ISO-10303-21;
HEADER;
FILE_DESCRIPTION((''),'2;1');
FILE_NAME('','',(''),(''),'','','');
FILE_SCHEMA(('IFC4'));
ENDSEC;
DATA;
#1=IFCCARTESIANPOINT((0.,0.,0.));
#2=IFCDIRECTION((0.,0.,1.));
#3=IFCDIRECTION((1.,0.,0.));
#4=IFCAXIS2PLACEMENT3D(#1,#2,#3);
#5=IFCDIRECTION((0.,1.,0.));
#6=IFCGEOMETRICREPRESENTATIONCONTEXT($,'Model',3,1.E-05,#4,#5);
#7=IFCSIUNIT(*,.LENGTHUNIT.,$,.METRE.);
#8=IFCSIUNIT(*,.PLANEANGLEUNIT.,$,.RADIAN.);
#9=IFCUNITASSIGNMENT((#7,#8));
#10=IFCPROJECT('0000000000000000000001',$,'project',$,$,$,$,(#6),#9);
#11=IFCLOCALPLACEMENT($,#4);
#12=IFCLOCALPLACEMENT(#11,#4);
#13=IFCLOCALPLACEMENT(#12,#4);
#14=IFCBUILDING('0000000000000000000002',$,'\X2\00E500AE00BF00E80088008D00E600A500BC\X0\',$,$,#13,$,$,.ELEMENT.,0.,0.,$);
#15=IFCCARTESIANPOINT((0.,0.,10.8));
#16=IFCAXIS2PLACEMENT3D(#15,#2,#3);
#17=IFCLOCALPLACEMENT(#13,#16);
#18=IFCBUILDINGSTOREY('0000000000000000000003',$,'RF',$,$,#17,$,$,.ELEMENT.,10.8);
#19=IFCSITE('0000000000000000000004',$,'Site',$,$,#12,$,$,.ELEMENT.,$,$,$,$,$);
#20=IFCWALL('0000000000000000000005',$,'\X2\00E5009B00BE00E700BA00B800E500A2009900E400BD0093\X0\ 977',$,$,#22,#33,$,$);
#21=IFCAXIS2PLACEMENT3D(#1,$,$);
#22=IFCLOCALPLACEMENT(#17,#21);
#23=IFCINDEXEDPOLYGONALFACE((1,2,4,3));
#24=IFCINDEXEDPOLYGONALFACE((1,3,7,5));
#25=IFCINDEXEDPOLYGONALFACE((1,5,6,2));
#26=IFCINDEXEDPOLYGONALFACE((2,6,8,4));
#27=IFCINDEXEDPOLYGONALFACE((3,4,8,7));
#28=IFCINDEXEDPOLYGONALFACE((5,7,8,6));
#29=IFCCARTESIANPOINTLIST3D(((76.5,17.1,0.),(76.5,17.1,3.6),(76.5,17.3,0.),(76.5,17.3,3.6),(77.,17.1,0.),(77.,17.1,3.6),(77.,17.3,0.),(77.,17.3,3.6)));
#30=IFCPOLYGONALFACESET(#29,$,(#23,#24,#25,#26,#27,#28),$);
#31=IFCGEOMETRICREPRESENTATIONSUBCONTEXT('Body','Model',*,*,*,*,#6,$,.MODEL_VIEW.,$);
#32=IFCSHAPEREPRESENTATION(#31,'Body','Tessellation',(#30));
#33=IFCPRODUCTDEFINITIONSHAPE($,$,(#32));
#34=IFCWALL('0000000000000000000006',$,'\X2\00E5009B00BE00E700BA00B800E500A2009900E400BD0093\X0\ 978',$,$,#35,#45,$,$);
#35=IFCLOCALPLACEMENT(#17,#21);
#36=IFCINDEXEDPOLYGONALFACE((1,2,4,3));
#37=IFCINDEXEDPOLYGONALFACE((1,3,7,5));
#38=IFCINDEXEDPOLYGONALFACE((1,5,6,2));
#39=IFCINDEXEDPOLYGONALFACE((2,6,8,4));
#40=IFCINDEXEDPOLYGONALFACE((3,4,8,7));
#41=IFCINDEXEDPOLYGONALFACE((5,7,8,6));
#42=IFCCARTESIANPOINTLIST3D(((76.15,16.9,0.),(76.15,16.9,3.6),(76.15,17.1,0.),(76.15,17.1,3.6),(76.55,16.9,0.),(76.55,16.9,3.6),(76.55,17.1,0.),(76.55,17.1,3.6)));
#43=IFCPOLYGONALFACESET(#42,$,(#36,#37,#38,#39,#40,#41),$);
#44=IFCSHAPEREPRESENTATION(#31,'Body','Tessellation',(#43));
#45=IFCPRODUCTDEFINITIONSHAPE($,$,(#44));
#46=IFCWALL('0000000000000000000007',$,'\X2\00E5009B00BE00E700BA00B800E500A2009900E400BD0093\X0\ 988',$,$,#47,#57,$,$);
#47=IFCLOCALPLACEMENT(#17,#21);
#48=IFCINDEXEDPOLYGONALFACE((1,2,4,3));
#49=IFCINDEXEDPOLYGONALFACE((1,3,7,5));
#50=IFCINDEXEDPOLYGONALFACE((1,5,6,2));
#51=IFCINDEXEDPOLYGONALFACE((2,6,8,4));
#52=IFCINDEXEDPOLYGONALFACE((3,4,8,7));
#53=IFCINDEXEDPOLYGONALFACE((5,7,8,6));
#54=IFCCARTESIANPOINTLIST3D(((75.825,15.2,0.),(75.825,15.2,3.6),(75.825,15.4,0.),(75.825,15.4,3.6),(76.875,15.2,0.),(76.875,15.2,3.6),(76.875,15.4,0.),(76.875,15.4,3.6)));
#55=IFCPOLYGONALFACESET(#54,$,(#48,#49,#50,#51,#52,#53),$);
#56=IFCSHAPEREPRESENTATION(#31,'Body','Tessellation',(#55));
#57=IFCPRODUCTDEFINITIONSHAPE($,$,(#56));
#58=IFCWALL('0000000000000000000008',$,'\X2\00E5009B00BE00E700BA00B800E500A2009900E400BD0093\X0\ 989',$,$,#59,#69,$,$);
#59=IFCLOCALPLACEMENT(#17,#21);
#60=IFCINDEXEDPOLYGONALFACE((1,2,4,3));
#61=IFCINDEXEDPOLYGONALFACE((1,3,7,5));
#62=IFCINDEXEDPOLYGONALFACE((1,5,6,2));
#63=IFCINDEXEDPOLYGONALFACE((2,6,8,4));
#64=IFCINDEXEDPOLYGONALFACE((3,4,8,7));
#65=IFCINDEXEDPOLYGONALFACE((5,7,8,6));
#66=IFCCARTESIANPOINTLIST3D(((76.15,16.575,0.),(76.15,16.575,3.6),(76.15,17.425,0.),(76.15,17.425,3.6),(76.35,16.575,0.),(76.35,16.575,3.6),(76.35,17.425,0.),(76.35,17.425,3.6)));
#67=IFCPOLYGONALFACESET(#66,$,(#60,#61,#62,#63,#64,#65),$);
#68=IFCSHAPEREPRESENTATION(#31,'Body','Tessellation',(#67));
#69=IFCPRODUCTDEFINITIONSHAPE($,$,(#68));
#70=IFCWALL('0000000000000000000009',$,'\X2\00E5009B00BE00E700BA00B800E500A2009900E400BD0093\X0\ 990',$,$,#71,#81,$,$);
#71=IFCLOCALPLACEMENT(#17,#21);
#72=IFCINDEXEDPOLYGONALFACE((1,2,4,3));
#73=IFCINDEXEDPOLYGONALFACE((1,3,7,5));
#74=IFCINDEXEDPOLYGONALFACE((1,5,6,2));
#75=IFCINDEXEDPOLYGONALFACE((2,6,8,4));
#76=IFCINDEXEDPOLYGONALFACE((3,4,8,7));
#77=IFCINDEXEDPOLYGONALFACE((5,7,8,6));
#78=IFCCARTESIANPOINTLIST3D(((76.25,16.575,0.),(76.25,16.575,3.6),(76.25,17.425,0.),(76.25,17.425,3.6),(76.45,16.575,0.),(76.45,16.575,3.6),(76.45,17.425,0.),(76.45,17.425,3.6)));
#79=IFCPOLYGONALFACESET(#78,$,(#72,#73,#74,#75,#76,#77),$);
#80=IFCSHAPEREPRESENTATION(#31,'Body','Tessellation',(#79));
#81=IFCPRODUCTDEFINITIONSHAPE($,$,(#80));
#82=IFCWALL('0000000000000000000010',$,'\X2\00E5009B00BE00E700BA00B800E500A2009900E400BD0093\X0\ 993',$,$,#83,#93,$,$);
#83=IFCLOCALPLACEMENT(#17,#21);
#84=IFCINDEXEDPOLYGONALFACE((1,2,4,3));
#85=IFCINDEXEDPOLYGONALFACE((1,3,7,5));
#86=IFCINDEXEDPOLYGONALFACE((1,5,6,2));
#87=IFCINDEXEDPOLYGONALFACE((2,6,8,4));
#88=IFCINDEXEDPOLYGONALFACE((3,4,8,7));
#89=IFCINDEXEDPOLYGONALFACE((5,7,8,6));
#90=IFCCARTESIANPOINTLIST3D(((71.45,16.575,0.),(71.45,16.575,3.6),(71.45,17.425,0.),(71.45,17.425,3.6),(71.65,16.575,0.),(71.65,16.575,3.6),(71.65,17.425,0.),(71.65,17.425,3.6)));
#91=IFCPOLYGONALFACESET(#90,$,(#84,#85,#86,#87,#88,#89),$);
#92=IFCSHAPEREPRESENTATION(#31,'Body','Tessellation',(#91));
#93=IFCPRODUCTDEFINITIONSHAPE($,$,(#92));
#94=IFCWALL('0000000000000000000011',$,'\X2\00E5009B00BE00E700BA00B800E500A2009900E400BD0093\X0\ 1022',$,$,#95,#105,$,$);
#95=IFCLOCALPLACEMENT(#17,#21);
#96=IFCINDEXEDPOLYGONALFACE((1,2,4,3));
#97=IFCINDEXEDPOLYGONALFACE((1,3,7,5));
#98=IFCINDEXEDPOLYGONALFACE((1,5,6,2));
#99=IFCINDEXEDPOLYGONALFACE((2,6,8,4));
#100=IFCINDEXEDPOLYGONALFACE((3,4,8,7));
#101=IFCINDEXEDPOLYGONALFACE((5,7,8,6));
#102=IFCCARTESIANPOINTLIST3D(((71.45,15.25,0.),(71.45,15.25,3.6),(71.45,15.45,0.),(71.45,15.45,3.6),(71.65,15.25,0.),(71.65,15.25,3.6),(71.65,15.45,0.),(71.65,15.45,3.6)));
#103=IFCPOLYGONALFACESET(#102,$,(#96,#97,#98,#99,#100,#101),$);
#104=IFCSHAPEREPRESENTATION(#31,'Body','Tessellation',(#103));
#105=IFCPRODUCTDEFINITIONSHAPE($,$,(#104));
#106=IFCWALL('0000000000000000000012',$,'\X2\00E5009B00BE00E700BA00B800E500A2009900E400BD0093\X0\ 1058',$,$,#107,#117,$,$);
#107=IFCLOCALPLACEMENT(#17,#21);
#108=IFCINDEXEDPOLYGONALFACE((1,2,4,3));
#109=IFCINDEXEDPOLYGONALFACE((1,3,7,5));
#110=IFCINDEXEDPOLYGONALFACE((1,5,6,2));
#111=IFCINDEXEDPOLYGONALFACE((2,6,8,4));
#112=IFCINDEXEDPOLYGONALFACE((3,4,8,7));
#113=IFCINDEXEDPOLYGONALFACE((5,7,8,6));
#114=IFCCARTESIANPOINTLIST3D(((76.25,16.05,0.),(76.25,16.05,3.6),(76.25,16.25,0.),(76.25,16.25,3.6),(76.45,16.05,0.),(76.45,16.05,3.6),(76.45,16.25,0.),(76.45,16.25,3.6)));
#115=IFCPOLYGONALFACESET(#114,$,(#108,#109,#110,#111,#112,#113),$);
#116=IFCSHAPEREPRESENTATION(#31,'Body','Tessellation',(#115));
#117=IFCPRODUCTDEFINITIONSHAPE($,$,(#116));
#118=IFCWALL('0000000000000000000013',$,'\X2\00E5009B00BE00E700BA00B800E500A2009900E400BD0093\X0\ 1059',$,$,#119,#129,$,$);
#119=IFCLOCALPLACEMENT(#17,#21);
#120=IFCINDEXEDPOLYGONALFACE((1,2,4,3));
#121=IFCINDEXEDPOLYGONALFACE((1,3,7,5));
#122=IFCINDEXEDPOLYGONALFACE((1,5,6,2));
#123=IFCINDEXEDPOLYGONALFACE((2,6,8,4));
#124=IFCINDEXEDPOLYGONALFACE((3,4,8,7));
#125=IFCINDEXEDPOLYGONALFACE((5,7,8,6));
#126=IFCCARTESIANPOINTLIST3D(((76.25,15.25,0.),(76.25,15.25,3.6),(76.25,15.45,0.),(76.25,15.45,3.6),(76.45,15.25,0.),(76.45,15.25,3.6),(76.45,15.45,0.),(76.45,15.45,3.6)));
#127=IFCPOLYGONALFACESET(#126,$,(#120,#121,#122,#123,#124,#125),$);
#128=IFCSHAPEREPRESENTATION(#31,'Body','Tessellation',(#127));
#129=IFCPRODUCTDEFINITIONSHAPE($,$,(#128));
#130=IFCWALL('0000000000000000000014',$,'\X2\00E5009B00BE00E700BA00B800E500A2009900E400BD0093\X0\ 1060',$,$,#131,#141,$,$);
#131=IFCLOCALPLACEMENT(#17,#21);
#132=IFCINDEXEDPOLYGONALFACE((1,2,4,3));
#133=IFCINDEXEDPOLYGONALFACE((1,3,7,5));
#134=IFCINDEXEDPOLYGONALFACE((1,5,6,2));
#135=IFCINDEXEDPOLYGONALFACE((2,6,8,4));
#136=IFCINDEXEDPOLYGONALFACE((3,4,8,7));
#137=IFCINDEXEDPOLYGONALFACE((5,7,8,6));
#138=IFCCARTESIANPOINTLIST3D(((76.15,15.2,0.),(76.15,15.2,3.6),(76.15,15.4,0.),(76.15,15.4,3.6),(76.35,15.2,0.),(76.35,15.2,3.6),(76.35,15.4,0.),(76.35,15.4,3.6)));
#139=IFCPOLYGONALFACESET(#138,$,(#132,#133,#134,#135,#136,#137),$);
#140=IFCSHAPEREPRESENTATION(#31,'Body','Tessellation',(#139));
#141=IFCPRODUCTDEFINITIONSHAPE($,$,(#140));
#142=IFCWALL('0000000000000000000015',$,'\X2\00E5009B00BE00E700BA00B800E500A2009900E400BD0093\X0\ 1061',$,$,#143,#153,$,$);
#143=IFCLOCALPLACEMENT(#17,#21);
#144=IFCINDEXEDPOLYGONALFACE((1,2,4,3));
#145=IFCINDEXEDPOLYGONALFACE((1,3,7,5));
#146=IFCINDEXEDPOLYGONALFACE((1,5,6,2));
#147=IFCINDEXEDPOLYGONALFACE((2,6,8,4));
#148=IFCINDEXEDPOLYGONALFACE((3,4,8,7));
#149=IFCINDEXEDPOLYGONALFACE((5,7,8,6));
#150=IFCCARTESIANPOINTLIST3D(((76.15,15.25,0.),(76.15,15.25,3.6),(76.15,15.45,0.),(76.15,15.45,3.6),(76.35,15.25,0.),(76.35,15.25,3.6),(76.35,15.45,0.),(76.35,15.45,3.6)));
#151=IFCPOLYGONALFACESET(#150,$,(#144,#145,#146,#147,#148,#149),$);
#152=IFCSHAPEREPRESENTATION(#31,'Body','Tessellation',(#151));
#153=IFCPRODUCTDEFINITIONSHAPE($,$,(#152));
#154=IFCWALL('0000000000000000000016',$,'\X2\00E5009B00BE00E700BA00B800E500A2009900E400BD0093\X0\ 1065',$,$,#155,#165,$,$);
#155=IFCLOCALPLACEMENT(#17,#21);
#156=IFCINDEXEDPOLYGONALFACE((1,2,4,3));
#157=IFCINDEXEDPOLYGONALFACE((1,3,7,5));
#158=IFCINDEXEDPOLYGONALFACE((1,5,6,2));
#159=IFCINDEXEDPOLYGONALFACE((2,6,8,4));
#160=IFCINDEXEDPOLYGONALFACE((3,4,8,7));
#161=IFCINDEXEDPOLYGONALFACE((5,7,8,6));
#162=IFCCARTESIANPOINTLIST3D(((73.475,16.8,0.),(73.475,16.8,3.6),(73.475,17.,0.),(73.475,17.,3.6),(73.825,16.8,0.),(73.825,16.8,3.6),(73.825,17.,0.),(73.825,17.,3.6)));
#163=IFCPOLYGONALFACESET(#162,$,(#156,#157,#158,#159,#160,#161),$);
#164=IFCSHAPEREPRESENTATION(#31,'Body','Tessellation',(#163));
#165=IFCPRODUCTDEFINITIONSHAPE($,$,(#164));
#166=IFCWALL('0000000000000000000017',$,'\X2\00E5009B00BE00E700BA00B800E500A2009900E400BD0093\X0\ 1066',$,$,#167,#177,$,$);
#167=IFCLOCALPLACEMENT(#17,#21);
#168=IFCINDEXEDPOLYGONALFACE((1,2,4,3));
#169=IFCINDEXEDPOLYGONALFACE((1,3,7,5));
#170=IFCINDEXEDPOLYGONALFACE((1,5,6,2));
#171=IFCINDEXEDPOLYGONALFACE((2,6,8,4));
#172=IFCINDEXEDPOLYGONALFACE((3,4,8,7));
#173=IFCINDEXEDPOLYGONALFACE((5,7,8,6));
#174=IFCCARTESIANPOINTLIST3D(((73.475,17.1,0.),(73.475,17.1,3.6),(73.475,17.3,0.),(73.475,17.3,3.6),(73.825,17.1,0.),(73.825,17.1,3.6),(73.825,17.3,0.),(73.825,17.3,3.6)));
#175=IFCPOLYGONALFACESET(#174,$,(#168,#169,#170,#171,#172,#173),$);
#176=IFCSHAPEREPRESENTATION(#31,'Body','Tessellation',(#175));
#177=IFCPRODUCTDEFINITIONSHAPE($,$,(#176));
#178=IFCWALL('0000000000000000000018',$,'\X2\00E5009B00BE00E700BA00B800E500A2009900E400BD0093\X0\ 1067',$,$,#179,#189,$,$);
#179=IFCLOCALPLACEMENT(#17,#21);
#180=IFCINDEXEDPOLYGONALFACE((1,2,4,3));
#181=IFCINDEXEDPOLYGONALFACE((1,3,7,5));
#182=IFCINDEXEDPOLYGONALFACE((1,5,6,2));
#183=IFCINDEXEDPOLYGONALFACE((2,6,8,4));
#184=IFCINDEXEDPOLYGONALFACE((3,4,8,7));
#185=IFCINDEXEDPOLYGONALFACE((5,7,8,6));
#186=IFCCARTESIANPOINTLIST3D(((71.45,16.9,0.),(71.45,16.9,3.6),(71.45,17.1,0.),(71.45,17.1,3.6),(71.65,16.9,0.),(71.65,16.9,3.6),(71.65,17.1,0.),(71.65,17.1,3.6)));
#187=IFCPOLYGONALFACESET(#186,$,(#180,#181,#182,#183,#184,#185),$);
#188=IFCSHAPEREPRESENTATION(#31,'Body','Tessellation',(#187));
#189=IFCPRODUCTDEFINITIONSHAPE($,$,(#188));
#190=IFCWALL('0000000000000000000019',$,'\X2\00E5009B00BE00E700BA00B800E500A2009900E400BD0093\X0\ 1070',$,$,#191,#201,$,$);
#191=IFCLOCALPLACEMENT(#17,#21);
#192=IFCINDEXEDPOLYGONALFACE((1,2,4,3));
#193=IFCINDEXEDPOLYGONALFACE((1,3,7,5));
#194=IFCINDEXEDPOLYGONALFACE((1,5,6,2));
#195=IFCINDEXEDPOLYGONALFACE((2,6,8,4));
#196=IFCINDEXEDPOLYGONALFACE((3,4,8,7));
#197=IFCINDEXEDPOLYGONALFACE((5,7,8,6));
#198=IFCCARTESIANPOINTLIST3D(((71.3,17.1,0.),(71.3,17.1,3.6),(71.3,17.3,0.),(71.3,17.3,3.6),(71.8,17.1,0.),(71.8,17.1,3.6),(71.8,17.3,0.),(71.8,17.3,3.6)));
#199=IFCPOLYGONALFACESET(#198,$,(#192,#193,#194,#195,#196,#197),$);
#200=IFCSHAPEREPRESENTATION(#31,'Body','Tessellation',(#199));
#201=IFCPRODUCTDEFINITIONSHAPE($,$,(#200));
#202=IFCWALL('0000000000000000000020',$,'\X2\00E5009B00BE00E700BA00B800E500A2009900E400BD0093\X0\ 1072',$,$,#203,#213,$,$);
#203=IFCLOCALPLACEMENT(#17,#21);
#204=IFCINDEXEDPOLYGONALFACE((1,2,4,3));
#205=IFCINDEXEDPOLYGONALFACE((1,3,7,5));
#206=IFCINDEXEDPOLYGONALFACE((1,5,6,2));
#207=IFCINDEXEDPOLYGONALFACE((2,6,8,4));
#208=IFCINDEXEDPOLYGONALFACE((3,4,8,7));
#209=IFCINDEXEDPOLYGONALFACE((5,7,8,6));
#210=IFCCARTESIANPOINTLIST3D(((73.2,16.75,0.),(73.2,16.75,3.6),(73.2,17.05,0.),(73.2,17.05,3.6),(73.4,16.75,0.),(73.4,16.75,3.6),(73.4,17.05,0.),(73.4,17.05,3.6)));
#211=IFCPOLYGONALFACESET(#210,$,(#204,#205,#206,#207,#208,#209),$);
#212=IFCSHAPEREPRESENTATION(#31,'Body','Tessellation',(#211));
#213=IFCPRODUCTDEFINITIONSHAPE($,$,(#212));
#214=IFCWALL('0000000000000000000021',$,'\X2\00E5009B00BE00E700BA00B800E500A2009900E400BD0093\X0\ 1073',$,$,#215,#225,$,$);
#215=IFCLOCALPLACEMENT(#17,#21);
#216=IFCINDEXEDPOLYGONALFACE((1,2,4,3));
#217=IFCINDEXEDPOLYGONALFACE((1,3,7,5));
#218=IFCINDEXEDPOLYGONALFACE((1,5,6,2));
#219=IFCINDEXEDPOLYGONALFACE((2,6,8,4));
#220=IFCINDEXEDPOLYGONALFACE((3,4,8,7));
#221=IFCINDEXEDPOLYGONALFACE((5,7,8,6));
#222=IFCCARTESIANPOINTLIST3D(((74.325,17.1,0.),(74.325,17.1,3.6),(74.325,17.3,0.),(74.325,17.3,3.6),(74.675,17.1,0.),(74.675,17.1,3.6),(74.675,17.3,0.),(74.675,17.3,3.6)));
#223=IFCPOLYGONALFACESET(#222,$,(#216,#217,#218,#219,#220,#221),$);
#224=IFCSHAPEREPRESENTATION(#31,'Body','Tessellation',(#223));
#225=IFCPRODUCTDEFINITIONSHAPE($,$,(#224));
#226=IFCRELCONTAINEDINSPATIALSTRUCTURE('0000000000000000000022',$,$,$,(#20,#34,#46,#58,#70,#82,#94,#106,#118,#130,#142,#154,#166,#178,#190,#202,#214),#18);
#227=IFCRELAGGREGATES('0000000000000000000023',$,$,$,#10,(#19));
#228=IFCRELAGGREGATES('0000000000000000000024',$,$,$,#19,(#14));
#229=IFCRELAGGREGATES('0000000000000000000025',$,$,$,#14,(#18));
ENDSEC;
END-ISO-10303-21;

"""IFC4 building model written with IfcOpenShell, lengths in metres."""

from ifc_helpers import new_model, si_unit, direction, frame, frame_2d, origin_with_axes, place, context, subcontext, project, spatial, rectangle, extrude, element, save


model = new_model("IFC4")

# Units and contexts
model_context = context("Model", 3, precision=1e-05, world=origin_with_axes(), true_north=direction((0.0, 1.0, 0.0)))
body_context = subcontext(model_context, "Body", "Model", "MODEL_VIEW")
ifc_project = project(units=[si_unit("LENGTHUNIT", "METRE"), si_unit("PLANEANGLEUNIT", "RADIAN")], contexts=[model_context])

# Site, building, storey
placement = place(None, origin_with_axes())
site_placement = place(placement, origin_with_axes())
site = spatial("IfcSite", under=ifc_project, at=site_placement, Name="Site", CompositionType="ELEMENT")
building_placement = place(site_placement, origin_with_axes())
building = spatial("IfcBuilding", under=site, at=building_placement, Name="å®¿è\u0088\u008dæ¥¼", CompositionType="ELEMENT", ElevationOfRefHeight=0.0, ElevationOfTerrain=0.0)
storey_placement = place(building_placement, frame((0.0, 0.0, 10.8), z_axis=(0.0, 0.0, 1.0), x_axis=(1.0, 0.0, 0.0)))
storey = spatial("IfcBuildingStorey", under=building, at=storey_placement, Name="RF", CompositionType="ELEMENT", Elevation=10.8)

# Walls
wall_1_placement = place(storey_placement, frame((76.75, 17.2, 0.0), z_axis=(0.0, 0.0, 1.0), x_axis=(-1.0, 0.0, 0.0)))
element("IfcWall", 1, at=wall_1_placement, inside=storey, Name="å\u009b¾çº¸å¢\u0099ä½\u0093 977", context=body_context, shape_type="SweptSolid", body=[
    extrude(rectangle(XDim=0.5, YDim=0.2, at=frame_2d((0.0, 0.0), x_axis=(1.0, 0.0, 0.0))), frame((0.0, 0.0, 0.0), z_axis=(0.0, 0.0, 1.0)), (0.0, 0.0, 1.0), 3.6),
])
wall_2_placement = place(storey_placement, frame((76.35, 17.0, 0.0), z_axis=(0.0, 0.0, 1.0), x_axis=(1.0, 0.0, 0.0)))
element("IfcWall", 2, at=wall_2_placement, inside=storey, Name="å\u009b¾çº¸å¢\u0099ä½\u0093 978", context=body_context, shape_type="SweptSolid", body=[
    extrude(rectangle(XDim=0.4, YDim=0.2, at=frame_2d((0.0, 0.0), x_axis=(1.0, 0.0, 0.0))), frame((0.0, 0.0, 0.0), z_axis=(0.0, 0.0, 1.0)), (0.0, 0.0, 1.0), 3.6),
])
wall_3_placement = place(storey_placement, frame((76.35, 15.3, 0.0), z_axis=(0.0, 0.0, 1.0), x_axis=(1.0, 0.0, 0.0)))
element("IfcWall", 3, at=wall_3_placement, inside=storey, Name="å\u009b¾çº¸å¢\u0099ä½\u0093 988", context=body_context, shape_type="SweptSolid", body=[
    extrude(rectangle(XDim=1.05, YDim=0.2, at=frame_2d((0.0, 0.0), x_axis=(1.0, 0.0, 0.0))), frame((0.0, 0.0, 0.0), z_axis=(0.0, 0.0, 1.0)), (0.0, 0.0, 1.0), 3.6),
])
for number, where, z_axis, x_axis, name in (
    (4, (76.25, 17.0, 0.0), (0.0, 0.0, 1.0), (0.0, -1.0, 0.0), "å\u009b¾çº¸å¢\u0099ä½\u0093 989"),
    (5, (76.35, 17.0, 0.0), (0.0, 0.0, 1.0), (0.0, -1.0, 0.0), "å\u009b¾çº¸å¢\u0099ä½\u0093 990"),
    (6, (71.55, 17.0, 0.0), (0.0, 0.0, 1.0), (0.0, -1.0, 0.0), "å\u009b¾çº¸å¢\u0099ä½\u0093 993"),
):
    element("IfcWall", number, at=place(storey_placement, frame(where, z_axis=z_axis, x_axis=x_axis)), inside=storey, Name=name, context=body_context, shape_type="SweptSolid", body=[
        extrude(rectangle(XDim=0.85, YDim=0.2, at=frame_2d((0.0, 0.0), x_axis=(1.0, 0.0, 0.0))), frame((0.0, 0.0, 0.0), z_axis=(0.0, 0.0, 1.0)), (0.0, 0.0, 1.0), 3.6),
    ])
for number, where, z_axis, x_axis, name in (
    (7, (71.55, 15.35, 0.0), (0.0, 0.0, 1.0), (0.0, -1.0, 0.0), "å\u009b¾çº¸å¢\u0099ä½\u0093 1022"),
    (8, (76.35, 16.15, 0.0), (0.0, 0.0, 1.0), (-1.0, 0.0, 0.0), "å\u009b¾çº¸å¢\u0099ä½\u0093 1058"),
    (9, (76.35, 15.35, 0.0), (0.0, 0.0, 1.0), (-1.0, 0.0, 0.0), "å\u009b¾çº¸å¢\u0099ä½\u0093 1059"),
    (10, (76.25, 15.3, 0.0), (0.0, 0.0, 1.0), (0.0, -1.0, 0.0), "å\u009b¾çº¸å¢\u0099ä½\u0093 1060"),
    (11, (76.25, 15.35, 0.0), (0.0, 0.0, 1.0), (0.0, -1.0, 0.0), "å\u009b¾çº¸å¢\u0099ä½\u0093 1061"),
):
    element("IfcWall", number, at=place(storey_placement, frame(where, z_axis=z_axis, x_axis=x_axis)), inside=storey, Name=name, context=body_context, shape_type="SweptSolid", body=[
        extrude(rectangle(XDim=0.2, YDim=0.2, at=frame_2d((0.0, 0.0), x_axis=(1.0, 0.0, 0.0))), frame((0.0, 0.0, 0.0), z_axis=(0.0, 0.0, 1.0)), (0.0, 0.0, 1.0), 3.6),
    ])
for number, where, z_axis, x_axis, name in (
    (12, (73.65, 16.9, 0.0), (0.0, 0.0, 1.0), (-1.0, 0.0, 0.0), "å\u009b¾çº¸å¢\u0099ä½\u0093 1065"),
    (13, (73.65, 17.2, 0.0), (0.0, 0.0, 1.0), (-1.0, 0.0, 0.0), "å\u009b¾çº¸å¢\u0099ä½\u0093 1066"),
):
    element("IfcWall", number, at=place(storey_placement, frame(where, z_axis=z_axis, x_axis=x_axis)), inside=storey, Name=name, context=body_context, shape_type="SweptSolid", body=[
        extrude(rectangle(XDim=0.35, YDim=0.2, at=frame_2d((0.0, 0.0), x_axis=(1.0, 0.0, 0.0))), frame((0.0, 0.0, 0.0), z_axis=(0.0, 0.0, 1.0)), (0.0, 0.0, 1.0), 3.6),
    ])
wall_4_placement = place(storey_placement, frame((71.55, 17.0, 0.0), z_axis=(0.0, 0.0, 1.0), x_axis=(0.0, 1.0, 0.0)))
element("IfcWall", 14, at=wall_4_placement, inside=storey, Name="å\u009b¾çº¸å¢\u0099ä½\u0093 1067", context=body_context, shape_type="SweptSolid", body=[
    extrude(rectangle(XDim=0.2, YDim=0.2, at=frame_2d((0.0, 0.0), x_axis=(1.0, 0.0, 0.0))), frame((0.0, 0.0, 0.0), z_axis=(0.0, 0.0, 1.0)), (0.0, 0.0, 1.0), 3.6),
])
wall_5_placement = place(storey_placement, frame((71.55, 17.2, 0.0), z_axis=(0.0, 0.0, 1.0), x_axis=(-1.0, 0.0, 0.0)))
element("IfcWall", 15, at=wall_5_placement, inside=storey, Name="å\u009b¾çº¸å¢\u0099ä½\u0093 1070", context=body_context, shape_type="SweptSolid", body=[
    extrude(rectangle(XDim=0.5, YDim=0.2, at=frame_2d((0.0, 0.0), x_axis=(1.0, 0.0, 0.0))), frame((0.0, 0.0, 0.0), z_axis=(0.0, 0.0, 1.0)), (0.0, 0.0, 1.0), 3.6),
])
wall_6_placement = place(storey_placement, frame((73.3, 16.9, 0.0), z_axis=(0.0, 0.0, 1.0), x_axis=(0.0, 1.0, 0.0)))
element("IfcWall", 16, at=wall_6_placement, inside=storey, Name="å\u009b¾çº¸å¢\u0099ä½\u0093 1072", context=body_context, shape_type="SweptSolid", body=[
    extrude(rectangle(XDim=0.3, YDim=0.2, at=frame_2d((0.0, 0.0), x_axis=(1.0, 0.0, 0.0))), frame((0.0, 0.0, 0.0), z_axis=(0.0, 0.0, 1.0)), (0.0, 0.0, 1.0), 3.6),
])
for number, where, z_axis, x_axis, name in (
    (17, (74.5, 17.2, 0.0), (0.0, 0.0, 1.0), (-1.0, 0.0, 0.0), "å\u009b¾çº¸å¢\u0099ä½\u0093 1073"),
):
    element("IfcWall", number, at=place(storey_placement, frame(where, z_axis=z_axis, x_axis=x_axis)), inside=storey, Name=name, context=body_context, shape_type="SweptSolid", body=[
        extrude(rectangle(XDim=0.35, YDim=0.2, at=frame_2d((0.0, 0.0), x_axis=(1.0, 0.0, 0.0))), frame((0.0, 0.0, 0.0), z_axis=(0.0, 0.0, 1.0)), (0.0, 0.0, 1.0), 3.6),
    ])

save(model, "model.ifc")
